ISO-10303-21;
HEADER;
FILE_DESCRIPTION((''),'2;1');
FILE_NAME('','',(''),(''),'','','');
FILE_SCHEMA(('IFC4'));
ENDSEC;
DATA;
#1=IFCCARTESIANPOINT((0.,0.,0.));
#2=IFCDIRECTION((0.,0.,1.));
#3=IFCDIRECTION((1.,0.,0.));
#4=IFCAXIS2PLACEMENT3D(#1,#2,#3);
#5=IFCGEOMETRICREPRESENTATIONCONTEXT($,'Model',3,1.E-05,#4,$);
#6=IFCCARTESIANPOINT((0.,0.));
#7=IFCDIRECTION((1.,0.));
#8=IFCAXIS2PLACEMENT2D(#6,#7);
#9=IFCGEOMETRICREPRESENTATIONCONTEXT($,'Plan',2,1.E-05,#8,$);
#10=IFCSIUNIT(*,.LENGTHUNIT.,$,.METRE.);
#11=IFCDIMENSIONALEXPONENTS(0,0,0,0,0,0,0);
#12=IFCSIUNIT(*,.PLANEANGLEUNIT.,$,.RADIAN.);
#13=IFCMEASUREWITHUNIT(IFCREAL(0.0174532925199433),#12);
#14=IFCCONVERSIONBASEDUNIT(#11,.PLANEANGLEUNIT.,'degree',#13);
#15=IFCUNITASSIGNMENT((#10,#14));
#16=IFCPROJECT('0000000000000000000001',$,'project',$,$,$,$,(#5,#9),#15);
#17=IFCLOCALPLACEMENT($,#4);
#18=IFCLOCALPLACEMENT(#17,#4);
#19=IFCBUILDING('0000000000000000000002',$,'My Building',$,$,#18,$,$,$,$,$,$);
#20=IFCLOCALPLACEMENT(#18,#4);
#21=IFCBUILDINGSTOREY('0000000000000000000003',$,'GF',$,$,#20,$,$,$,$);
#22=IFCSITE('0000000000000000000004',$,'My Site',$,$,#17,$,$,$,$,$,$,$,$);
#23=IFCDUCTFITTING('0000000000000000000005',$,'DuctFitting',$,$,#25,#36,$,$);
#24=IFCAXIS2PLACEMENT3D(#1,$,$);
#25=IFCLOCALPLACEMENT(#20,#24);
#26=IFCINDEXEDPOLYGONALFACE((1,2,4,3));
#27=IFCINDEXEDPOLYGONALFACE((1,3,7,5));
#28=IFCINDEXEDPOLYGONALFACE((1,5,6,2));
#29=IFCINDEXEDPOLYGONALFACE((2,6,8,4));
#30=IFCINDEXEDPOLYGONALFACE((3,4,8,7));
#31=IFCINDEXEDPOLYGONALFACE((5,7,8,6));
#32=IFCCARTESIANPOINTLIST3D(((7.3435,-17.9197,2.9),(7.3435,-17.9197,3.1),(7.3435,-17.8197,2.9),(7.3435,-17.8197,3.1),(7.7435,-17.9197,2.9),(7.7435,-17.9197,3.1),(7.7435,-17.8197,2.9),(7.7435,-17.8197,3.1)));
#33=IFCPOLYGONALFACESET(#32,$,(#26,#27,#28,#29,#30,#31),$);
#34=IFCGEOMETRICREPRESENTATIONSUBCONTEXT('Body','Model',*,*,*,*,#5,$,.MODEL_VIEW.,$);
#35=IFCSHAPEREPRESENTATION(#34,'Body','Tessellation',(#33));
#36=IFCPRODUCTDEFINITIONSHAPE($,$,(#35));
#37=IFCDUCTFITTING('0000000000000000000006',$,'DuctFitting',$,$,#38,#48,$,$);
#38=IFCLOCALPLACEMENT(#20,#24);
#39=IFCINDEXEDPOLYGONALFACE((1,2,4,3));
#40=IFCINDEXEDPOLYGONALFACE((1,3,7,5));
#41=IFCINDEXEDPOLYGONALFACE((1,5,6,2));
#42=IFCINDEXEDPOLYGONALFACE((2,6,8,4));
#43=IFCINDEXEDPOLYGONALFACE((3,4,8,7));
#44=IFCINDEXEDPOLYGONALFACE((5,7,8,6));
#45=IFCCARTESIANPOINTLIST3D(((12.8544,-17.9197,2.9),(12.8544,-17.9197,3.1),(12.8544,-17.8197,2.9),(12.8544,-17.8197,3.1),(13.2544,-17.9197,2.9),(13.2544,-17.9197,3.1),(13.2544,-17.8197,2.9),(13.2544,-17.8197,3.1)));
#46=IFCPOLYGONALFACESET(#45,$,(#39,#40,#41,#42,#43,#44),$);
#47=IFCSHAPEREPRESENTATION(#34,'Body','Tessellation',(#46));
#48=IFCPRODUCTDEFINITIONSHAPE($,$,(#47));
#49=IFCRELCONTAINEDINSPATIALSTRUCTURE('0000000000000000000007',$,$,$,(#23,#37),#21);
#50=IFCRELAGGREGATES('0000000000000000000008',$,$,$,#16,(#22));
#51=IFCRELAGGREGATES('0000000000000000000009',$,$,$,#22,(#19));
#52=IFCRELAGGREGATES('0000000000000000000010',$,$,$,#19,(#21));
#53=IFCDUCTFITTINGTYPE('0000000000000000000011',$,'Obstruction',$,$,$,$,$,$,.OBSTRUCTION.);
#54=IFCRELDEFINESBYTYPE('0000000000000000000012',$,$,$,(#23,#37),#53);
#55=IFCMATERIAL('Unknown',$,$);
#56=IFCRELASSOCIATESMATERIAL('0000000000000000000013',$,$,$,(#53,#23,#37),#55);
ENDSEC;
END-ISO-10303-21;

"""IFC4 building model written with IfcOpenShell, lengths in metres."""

from ifc_helpers import new_model, entity, si_unit, converted_unit, frame, origin_with_axes, origin_2d_with_axis, place, context, subcontext, project, spatial, rectangle, extrude, material, material_profile, profile_set, profile_usage, type_object, element, save


model = new_model("IFC4")

# Units and contexts
model_context = context("Model", 3, precision=1e-05, world=origin_with_axes())
plan_context = context("Plan", 2, precision=1e-05, world=origin_2d_with_axis())
body_context_1 = subcontext(model_context, "Body", "Model", "MODEL_VIEW")
ifc_project = project(units=[si_unit("LENGTHUNIT", "METRE"), converted_unit("PLANEANGLEUNIT", "degree", entity("IfcReal", 0.0174532925199433), si_unit("PLANEANGLEUNIT", "RADIAN"), dimensions=[0, 0, 0, 0, 0, 0, 0])], contexts=[model_context, plan_context])

# Site, building, storey
site_placement = place(None, origin_with_axes())
site = spatial("IfcSite", under=ifc_project, at=site_placement, Name="My Site")
building_placement = place(site_placement, origin_with_axes())
building = spatial("IfcBuilding", under=site, at=building_placement, Name="My Building")
storey_placement = place(building_placement, origin_with_axes())
storey = spatial("IfcBuildingStorey", under=building, at=storey_placement, Name="GF")

# Shared definitions
ifc_material = material(Name="Unknown")

# Duct fittings
ifc_material_profile = material_profile(ifc_material, rectangle(XDim=0.4, YDim=0.2))
ifc_profile_set = profile_set([ifc_material_profile])
ifc_profile_usage_1 = profile_usage(ifc_profile_set, cardinal=5)
duct_fitting_type = type_object("IfcDuctFittingType", Name="Obstruction", PredefinedType="OBSTRUCTION", material=ifc_profile_set)
duct_fitting_1_placement = place(storey_placement, frame((7.5435, -17.9197, 3.0), z_axis=(0.0, 1.0, 0.0), x_axis=(-1.0, 0.0, 0.0)))
element("IfcDuctFitting", 1, at=duct_fitting_1_placement, inside=storey, type_object=duct_fitting_type, material=ifc_profile_usage_1, Name="DuctFitting", context=body_context_1, shape_type="SweptSolid", body=[
    extrude(rectangle(XDim=0.4, YDim=0.2), origin_with_axes(), (0.0, 0.0, 1.0), 0.1),
])
ifc_profile_usage_2 = profile_usage(ifc_profile_set, cardinal=5)
duct_fitting_2_placement = place(storey_placement, frame((13.0544, -17.9197, 3.0), z_axis=(0.0, 1.0, 0.0), x_axis=(-1.0, 0.0, 0.0)))
element("IfcDuctFitting", 2, at=duct_fitting_2_placement, inside=storey, type_object=duct_fitting_type, material=ifc_profile_usage_2, Name="DuctFitting", context=body_context_1, shape_type="SweptSolid", body=[
    extrude(rectangle(XDim=0.4, YDim=0.2), origin_with_axes(), (0.0, 0.0, 1.0), 0.1),
])

save(model, "model.ifc")
